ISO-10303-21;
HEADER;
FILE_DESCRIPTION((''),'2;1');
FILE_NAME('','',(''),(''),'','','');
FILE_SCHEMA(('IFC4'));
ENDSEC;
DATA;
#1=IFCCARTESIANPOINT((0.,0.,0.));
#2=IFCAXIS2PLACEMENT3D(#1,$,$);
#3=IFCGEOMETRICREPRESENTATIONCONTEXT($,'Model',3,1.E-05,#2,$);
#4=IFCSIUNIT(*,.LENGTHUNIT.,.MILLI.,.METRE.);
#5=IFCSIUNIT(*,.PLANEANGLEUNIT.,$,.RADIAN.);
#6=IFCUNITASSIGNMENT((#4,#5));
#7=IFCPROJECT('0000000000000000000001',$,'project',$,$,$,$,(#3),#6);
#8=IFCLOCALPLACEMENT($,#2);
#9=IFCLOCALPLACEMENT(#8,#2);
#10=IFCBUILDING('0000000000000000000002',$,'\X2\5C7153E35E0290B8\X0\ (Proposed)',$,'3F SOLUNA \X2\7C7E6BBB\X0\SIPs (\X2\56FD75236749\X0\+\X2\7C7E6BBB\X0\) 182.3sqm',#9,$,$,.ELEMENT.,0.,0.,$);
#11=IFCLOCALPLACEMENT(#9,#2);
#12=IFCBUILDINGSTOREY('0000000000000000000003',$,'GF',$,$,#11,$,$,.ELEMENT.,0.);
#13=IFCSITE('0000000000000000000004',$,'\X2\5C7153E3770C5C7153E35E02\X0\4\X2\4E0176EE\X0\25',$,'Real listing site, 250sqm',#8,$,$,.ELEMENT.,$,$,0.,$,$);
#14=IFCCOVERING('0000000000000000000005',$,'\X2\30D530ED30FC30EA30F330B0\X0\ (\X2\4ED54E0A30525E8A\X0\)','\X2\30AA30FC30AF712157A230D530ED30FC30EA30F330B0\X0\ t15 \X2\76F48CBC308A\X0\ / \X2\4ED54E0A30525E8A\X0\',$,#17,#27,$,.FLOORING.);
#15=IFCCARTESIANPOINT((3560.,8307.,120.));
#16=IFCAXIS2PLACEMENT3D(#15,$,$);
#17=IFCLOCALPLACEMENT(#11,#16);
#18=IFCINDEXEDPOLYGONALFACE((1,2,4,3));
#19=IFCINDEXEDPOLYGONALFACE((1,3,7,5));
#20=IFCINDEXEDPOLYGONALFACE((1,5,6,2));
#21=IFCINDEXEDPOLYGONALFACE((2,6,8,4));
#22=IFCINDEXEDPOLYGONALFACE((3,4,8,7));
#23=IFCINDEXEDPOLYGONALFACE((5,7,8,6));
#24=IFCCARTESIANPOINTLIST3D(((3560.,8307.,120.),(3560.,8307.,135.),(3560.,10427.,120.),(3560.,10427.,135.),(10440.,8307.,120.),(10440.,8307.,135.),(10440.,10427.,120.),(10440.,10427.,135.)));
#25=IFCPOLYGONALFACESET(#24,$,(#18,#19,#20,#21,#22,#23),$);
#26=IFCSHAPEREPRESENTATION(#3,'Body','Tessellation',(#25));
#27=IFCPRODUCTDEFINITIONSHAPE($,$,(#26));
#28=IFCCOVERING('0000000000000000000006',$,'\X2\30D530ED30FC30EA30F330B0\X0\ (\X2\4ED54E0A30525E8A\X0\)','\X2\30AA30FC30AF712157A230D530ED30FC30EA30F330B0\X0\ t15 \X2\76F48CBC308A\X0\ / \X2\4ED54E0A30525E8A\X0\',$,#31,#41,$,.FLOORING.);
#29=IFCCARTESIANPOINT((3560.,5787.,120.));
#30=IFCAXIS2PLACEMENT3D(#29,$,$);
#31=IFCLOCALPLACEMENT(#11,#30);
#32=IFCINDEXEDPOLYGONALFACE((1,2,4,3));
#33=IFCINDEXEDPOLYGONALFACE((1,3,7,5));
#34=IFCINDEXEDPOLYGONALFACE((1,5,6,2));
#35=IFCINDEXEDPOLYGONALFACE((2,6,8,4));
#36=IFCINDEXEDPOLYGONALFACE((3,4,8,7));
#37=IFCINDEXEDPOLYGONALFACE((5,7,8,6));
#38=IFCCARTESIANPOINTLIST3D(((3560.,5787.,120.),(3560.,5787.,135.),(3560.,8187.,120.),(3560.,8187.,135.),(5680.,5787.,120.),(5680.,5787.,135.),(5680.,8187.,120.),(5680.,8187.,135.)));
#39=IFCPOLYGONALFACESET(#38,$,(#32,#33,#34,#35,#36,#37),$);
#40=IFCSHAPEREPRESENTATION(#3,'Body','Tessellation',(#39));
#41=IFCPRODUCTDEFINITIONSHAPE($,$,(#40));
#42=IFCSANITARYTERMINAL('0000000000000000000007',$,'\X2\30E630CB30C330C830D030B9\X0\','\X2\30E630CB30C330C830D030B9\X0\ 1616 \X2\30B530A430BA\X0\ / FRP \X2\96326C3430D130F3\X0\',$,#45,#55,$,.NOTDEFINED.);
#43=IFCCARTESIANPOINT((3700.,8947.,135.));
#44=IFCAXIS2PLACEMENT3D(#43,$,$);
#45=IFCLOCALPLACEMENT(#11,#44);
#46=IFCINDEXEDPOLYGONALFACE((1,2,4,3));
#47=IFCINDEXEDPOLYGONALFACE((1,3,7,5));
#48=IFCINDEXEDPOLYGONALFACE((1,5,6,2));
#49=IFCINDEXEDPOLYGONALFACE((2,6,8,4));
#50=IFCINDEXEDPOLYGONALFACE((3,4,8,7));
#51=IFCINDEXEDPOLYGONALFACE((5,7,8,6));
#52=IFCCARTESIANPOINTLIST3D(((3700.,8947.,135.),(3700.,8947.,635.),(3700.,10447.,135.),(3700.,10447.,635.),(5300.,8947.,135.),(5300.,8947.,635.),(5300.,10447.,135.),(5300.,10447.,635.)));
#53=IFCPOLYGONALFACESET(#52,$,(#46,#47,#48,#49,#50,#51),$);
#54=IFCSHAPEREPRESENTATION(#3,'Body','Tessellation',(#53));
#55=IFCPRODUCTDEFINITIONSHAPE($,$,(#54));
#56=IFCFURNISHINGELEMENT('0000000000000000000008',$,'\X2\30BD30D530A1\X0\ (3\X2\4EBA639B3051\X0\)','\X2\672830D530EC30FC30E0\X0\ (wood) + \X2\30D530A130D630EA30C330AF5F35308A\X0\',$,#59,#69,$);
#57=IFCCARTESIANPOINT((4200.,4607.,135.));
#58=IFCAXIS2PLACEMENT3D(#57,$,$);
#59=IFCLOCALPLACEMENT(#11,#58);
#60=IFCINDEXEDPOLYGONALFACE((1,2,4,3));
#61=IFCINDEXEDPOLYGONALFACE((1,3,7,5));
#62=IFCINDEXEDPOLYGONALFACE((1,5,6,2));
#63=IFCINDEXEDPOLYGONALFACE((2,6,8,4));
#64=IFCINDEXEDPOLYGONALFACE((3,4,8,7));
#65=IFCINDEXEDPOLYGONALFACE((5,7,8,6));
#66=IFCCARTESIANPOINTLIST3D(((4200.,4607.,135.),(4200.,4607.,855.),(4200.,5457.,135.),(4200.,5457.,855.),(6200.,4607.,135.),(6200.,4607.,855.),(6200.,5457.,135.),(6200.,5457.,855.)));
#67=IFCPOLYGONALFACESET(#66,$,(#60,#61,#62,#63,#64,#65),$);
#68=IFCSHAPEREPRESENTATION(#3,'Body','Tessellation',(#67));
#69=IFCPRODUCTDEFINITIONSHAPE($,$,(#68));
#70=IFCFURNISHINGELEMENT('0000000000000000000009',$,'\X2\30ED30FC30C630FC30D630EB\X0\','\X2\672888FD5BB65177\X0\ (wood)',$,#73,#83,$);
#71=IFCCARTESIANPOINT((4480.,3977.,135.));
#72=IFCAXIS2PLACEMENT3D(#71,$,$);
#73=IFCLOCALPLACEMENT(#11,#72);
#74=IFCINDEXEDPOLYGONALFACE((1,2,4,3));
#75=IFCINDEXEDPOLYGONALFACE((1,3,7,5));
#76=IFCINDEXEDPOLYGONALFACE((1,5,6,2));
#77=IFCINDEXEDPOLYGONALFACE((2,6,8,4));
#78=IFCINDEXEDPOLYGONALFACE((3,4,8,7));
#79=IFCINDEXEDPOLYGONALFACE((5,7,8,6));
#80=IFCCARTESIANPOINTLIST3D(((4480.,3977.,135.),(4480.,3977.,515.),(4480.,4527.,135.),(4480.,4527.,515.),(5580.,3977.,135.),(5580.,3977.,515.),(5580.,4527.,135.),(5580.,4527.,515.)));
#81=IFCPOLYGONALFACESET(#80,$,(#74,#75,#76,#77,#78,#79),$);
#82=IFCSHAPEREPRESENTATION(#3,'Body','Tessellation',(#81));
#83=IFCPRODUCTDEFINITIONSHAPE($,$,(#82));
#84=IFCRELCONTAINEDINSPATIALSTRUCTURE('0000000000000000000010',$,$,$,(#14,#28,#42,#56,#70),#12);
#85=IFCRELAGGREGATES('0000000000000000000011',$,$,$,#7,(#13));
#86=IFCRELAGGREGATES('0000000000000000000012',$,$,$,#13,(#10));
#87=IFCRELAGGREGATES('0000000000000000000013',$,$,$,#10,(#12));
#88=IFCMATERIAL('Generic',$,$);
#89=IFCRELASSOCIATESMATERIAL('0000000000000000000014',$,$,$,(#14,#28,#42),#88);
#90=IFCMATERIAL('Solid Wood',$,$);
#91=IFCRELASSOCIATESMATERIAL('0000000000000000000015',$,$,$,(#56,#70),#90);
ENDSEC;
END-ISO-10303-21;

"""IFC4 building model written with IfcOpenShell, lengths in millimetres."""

from ifc_helpers import new_model, si_unit, frame, frame_2d, origin, place, context, project, spatial, rectangle, extrude, material, element, save


model = new_model("IFC4")

# Units and contexts
model_context = context("Model", 3, precision=1e-05, world=origin())
ifc_project = project(units=[si_unit("LENGTHUNIT", "METRE", prefix="MILLI"), si_unit("PLANEANGLEUNIT", "RADIAN")], contexts=[model_context])

# Site, building, storey
site_placement = place(None, origin())
site = spatial("IfcSite", under=ifc_project, at=site_placement, Name="山口県山口市4丁目25", ObjectType="Real listing site, 250sqm", CompositionType="ELEMENT", RefElevation=0.0)
building_placement = place(site_placement, origin())
building = spatial("IfcBuilding", under=site, at=building_placement, Name="山口市邸 (Proposed)", ObjectType="3F SOLUNA 籾殻SIPs (国産杉+籾殻) 182.3sqm", CompositionType="ELEMENT", ElevationOfRefHeight=0.0, ElevationOfTerrain=0.0)
storey_placement = place(building_placement, origin())
storey = spatial("IfcBuildingStorey", under=building, at=storey_placement, Name="GF", CompositionType="ELEMENT", Elevation=0.0)

# Shared definitions
ifc_material_1 = material(Name="Solid Wood")

# Coverings
ifc_material_2 = material(Name="Generic")
covering_1_placement = place(storey_placement, frame((3560.0, 8307.0, 120.0)))
element("IfcCovering", 1, at=covering_1_placement, inside=storey, material=ifc_material_2, Name="フローリング (仕上げ床)", Description="オーク無垢フローリング t15 直貼り / 仕上げ床", PredefinedType="FLOORING", context=model_context, shape_type="SweptSolid", body=[
    extrude(rectangle(XDim=6880.0, YDim=2120.0, at=frame_2d((3440.0, 1060.0))), frame((3560.0, 8307.0, 120.0)), (0.0, 0.0, 1.0), 15.0),
])
covering_2_placement = place(storey_placement, frame((3560.0, 5787.0, 120.0)))
element("IfcCovering", 2, at=covering_2_placement, inside=storey, material=ifc_material_2, Name="フローリング (仕上げ床)", Description="オーク無垢フローリング t15 直貼り / 仕上げ床", PredefinedType="FLOORING", context=model_context, shape_type="SweptSolid", body=[
    extrude(rectangle(XDim=2120.0, YDim=2400.0, at=frame_2d((1060.0, 1200.0))), frame((3560.0, 5787.0, 120.0)), (0.0, 0.0, 1.0), 15.0),
])

# Sanitary terminal
sanitary_terminal_placement = place(storey_placement, frame((3700.0, 8947.0, 135.0)))
element("IfcSanitaryTerminal", 3, at=sanitary_terminal_placement, inside=storey, material=ifc_material_2, Name="ユニットバス", Description="ユニットバス 1616 サイズ / FRP 防水パン", PredefinedType="NOTDEFINED", context=model_context, shape_type="SweptSolid", body=[
    extrude(rectangle(XDim=1600.0, YDim=1500.0, at=frame_2d((800.0, 750.0))), frame((3700.0, 8947.0, 135.0)), (0.0, 0.0, 1.0), 500.0),
])

# Furnishing elements
furnishing_1_placement = place(storey_placement, frame((4200.0, 4607.0, 135.0)))
element("IfcFurnishingElement", 4, at=furnishing_1_placement, inside=storey, material=ifc_material_1, Name="ソファ (3人掛け)", Description="木フレーム (wood) + ファブリック張り", context=model_context, shape_type="SweptSolid", body=[
    extrude(rectangle(XDim=2000.0, YDim=850.0, at=frame_2d((1000.0, 425.0))), frame((4200.0, 4607.0, 135.0)), (0.0, 0.0, 1.0), 720.0),
])
furnishing_2_placement = place(storey_placement, frame((4480.0, 3977.0, 135.0)))
element("IfcFurnishingElement", 5, at=furnishing_2_placement, inside=storey, material=ifc_material_1, Name="ローテーブル", Description="木製家具 (wood)", context=model_context, shape_type="SweptSolid", body=[
    extrude(rectangle(XDim=1100.0, YDim=550.0, at=frame_2d((550.0, 275.0))), frame((4480.0, 3977.0, 135.0)), (0.0, 0.0, 1.0), 380.0),
])

save(model, "model.ifc")
